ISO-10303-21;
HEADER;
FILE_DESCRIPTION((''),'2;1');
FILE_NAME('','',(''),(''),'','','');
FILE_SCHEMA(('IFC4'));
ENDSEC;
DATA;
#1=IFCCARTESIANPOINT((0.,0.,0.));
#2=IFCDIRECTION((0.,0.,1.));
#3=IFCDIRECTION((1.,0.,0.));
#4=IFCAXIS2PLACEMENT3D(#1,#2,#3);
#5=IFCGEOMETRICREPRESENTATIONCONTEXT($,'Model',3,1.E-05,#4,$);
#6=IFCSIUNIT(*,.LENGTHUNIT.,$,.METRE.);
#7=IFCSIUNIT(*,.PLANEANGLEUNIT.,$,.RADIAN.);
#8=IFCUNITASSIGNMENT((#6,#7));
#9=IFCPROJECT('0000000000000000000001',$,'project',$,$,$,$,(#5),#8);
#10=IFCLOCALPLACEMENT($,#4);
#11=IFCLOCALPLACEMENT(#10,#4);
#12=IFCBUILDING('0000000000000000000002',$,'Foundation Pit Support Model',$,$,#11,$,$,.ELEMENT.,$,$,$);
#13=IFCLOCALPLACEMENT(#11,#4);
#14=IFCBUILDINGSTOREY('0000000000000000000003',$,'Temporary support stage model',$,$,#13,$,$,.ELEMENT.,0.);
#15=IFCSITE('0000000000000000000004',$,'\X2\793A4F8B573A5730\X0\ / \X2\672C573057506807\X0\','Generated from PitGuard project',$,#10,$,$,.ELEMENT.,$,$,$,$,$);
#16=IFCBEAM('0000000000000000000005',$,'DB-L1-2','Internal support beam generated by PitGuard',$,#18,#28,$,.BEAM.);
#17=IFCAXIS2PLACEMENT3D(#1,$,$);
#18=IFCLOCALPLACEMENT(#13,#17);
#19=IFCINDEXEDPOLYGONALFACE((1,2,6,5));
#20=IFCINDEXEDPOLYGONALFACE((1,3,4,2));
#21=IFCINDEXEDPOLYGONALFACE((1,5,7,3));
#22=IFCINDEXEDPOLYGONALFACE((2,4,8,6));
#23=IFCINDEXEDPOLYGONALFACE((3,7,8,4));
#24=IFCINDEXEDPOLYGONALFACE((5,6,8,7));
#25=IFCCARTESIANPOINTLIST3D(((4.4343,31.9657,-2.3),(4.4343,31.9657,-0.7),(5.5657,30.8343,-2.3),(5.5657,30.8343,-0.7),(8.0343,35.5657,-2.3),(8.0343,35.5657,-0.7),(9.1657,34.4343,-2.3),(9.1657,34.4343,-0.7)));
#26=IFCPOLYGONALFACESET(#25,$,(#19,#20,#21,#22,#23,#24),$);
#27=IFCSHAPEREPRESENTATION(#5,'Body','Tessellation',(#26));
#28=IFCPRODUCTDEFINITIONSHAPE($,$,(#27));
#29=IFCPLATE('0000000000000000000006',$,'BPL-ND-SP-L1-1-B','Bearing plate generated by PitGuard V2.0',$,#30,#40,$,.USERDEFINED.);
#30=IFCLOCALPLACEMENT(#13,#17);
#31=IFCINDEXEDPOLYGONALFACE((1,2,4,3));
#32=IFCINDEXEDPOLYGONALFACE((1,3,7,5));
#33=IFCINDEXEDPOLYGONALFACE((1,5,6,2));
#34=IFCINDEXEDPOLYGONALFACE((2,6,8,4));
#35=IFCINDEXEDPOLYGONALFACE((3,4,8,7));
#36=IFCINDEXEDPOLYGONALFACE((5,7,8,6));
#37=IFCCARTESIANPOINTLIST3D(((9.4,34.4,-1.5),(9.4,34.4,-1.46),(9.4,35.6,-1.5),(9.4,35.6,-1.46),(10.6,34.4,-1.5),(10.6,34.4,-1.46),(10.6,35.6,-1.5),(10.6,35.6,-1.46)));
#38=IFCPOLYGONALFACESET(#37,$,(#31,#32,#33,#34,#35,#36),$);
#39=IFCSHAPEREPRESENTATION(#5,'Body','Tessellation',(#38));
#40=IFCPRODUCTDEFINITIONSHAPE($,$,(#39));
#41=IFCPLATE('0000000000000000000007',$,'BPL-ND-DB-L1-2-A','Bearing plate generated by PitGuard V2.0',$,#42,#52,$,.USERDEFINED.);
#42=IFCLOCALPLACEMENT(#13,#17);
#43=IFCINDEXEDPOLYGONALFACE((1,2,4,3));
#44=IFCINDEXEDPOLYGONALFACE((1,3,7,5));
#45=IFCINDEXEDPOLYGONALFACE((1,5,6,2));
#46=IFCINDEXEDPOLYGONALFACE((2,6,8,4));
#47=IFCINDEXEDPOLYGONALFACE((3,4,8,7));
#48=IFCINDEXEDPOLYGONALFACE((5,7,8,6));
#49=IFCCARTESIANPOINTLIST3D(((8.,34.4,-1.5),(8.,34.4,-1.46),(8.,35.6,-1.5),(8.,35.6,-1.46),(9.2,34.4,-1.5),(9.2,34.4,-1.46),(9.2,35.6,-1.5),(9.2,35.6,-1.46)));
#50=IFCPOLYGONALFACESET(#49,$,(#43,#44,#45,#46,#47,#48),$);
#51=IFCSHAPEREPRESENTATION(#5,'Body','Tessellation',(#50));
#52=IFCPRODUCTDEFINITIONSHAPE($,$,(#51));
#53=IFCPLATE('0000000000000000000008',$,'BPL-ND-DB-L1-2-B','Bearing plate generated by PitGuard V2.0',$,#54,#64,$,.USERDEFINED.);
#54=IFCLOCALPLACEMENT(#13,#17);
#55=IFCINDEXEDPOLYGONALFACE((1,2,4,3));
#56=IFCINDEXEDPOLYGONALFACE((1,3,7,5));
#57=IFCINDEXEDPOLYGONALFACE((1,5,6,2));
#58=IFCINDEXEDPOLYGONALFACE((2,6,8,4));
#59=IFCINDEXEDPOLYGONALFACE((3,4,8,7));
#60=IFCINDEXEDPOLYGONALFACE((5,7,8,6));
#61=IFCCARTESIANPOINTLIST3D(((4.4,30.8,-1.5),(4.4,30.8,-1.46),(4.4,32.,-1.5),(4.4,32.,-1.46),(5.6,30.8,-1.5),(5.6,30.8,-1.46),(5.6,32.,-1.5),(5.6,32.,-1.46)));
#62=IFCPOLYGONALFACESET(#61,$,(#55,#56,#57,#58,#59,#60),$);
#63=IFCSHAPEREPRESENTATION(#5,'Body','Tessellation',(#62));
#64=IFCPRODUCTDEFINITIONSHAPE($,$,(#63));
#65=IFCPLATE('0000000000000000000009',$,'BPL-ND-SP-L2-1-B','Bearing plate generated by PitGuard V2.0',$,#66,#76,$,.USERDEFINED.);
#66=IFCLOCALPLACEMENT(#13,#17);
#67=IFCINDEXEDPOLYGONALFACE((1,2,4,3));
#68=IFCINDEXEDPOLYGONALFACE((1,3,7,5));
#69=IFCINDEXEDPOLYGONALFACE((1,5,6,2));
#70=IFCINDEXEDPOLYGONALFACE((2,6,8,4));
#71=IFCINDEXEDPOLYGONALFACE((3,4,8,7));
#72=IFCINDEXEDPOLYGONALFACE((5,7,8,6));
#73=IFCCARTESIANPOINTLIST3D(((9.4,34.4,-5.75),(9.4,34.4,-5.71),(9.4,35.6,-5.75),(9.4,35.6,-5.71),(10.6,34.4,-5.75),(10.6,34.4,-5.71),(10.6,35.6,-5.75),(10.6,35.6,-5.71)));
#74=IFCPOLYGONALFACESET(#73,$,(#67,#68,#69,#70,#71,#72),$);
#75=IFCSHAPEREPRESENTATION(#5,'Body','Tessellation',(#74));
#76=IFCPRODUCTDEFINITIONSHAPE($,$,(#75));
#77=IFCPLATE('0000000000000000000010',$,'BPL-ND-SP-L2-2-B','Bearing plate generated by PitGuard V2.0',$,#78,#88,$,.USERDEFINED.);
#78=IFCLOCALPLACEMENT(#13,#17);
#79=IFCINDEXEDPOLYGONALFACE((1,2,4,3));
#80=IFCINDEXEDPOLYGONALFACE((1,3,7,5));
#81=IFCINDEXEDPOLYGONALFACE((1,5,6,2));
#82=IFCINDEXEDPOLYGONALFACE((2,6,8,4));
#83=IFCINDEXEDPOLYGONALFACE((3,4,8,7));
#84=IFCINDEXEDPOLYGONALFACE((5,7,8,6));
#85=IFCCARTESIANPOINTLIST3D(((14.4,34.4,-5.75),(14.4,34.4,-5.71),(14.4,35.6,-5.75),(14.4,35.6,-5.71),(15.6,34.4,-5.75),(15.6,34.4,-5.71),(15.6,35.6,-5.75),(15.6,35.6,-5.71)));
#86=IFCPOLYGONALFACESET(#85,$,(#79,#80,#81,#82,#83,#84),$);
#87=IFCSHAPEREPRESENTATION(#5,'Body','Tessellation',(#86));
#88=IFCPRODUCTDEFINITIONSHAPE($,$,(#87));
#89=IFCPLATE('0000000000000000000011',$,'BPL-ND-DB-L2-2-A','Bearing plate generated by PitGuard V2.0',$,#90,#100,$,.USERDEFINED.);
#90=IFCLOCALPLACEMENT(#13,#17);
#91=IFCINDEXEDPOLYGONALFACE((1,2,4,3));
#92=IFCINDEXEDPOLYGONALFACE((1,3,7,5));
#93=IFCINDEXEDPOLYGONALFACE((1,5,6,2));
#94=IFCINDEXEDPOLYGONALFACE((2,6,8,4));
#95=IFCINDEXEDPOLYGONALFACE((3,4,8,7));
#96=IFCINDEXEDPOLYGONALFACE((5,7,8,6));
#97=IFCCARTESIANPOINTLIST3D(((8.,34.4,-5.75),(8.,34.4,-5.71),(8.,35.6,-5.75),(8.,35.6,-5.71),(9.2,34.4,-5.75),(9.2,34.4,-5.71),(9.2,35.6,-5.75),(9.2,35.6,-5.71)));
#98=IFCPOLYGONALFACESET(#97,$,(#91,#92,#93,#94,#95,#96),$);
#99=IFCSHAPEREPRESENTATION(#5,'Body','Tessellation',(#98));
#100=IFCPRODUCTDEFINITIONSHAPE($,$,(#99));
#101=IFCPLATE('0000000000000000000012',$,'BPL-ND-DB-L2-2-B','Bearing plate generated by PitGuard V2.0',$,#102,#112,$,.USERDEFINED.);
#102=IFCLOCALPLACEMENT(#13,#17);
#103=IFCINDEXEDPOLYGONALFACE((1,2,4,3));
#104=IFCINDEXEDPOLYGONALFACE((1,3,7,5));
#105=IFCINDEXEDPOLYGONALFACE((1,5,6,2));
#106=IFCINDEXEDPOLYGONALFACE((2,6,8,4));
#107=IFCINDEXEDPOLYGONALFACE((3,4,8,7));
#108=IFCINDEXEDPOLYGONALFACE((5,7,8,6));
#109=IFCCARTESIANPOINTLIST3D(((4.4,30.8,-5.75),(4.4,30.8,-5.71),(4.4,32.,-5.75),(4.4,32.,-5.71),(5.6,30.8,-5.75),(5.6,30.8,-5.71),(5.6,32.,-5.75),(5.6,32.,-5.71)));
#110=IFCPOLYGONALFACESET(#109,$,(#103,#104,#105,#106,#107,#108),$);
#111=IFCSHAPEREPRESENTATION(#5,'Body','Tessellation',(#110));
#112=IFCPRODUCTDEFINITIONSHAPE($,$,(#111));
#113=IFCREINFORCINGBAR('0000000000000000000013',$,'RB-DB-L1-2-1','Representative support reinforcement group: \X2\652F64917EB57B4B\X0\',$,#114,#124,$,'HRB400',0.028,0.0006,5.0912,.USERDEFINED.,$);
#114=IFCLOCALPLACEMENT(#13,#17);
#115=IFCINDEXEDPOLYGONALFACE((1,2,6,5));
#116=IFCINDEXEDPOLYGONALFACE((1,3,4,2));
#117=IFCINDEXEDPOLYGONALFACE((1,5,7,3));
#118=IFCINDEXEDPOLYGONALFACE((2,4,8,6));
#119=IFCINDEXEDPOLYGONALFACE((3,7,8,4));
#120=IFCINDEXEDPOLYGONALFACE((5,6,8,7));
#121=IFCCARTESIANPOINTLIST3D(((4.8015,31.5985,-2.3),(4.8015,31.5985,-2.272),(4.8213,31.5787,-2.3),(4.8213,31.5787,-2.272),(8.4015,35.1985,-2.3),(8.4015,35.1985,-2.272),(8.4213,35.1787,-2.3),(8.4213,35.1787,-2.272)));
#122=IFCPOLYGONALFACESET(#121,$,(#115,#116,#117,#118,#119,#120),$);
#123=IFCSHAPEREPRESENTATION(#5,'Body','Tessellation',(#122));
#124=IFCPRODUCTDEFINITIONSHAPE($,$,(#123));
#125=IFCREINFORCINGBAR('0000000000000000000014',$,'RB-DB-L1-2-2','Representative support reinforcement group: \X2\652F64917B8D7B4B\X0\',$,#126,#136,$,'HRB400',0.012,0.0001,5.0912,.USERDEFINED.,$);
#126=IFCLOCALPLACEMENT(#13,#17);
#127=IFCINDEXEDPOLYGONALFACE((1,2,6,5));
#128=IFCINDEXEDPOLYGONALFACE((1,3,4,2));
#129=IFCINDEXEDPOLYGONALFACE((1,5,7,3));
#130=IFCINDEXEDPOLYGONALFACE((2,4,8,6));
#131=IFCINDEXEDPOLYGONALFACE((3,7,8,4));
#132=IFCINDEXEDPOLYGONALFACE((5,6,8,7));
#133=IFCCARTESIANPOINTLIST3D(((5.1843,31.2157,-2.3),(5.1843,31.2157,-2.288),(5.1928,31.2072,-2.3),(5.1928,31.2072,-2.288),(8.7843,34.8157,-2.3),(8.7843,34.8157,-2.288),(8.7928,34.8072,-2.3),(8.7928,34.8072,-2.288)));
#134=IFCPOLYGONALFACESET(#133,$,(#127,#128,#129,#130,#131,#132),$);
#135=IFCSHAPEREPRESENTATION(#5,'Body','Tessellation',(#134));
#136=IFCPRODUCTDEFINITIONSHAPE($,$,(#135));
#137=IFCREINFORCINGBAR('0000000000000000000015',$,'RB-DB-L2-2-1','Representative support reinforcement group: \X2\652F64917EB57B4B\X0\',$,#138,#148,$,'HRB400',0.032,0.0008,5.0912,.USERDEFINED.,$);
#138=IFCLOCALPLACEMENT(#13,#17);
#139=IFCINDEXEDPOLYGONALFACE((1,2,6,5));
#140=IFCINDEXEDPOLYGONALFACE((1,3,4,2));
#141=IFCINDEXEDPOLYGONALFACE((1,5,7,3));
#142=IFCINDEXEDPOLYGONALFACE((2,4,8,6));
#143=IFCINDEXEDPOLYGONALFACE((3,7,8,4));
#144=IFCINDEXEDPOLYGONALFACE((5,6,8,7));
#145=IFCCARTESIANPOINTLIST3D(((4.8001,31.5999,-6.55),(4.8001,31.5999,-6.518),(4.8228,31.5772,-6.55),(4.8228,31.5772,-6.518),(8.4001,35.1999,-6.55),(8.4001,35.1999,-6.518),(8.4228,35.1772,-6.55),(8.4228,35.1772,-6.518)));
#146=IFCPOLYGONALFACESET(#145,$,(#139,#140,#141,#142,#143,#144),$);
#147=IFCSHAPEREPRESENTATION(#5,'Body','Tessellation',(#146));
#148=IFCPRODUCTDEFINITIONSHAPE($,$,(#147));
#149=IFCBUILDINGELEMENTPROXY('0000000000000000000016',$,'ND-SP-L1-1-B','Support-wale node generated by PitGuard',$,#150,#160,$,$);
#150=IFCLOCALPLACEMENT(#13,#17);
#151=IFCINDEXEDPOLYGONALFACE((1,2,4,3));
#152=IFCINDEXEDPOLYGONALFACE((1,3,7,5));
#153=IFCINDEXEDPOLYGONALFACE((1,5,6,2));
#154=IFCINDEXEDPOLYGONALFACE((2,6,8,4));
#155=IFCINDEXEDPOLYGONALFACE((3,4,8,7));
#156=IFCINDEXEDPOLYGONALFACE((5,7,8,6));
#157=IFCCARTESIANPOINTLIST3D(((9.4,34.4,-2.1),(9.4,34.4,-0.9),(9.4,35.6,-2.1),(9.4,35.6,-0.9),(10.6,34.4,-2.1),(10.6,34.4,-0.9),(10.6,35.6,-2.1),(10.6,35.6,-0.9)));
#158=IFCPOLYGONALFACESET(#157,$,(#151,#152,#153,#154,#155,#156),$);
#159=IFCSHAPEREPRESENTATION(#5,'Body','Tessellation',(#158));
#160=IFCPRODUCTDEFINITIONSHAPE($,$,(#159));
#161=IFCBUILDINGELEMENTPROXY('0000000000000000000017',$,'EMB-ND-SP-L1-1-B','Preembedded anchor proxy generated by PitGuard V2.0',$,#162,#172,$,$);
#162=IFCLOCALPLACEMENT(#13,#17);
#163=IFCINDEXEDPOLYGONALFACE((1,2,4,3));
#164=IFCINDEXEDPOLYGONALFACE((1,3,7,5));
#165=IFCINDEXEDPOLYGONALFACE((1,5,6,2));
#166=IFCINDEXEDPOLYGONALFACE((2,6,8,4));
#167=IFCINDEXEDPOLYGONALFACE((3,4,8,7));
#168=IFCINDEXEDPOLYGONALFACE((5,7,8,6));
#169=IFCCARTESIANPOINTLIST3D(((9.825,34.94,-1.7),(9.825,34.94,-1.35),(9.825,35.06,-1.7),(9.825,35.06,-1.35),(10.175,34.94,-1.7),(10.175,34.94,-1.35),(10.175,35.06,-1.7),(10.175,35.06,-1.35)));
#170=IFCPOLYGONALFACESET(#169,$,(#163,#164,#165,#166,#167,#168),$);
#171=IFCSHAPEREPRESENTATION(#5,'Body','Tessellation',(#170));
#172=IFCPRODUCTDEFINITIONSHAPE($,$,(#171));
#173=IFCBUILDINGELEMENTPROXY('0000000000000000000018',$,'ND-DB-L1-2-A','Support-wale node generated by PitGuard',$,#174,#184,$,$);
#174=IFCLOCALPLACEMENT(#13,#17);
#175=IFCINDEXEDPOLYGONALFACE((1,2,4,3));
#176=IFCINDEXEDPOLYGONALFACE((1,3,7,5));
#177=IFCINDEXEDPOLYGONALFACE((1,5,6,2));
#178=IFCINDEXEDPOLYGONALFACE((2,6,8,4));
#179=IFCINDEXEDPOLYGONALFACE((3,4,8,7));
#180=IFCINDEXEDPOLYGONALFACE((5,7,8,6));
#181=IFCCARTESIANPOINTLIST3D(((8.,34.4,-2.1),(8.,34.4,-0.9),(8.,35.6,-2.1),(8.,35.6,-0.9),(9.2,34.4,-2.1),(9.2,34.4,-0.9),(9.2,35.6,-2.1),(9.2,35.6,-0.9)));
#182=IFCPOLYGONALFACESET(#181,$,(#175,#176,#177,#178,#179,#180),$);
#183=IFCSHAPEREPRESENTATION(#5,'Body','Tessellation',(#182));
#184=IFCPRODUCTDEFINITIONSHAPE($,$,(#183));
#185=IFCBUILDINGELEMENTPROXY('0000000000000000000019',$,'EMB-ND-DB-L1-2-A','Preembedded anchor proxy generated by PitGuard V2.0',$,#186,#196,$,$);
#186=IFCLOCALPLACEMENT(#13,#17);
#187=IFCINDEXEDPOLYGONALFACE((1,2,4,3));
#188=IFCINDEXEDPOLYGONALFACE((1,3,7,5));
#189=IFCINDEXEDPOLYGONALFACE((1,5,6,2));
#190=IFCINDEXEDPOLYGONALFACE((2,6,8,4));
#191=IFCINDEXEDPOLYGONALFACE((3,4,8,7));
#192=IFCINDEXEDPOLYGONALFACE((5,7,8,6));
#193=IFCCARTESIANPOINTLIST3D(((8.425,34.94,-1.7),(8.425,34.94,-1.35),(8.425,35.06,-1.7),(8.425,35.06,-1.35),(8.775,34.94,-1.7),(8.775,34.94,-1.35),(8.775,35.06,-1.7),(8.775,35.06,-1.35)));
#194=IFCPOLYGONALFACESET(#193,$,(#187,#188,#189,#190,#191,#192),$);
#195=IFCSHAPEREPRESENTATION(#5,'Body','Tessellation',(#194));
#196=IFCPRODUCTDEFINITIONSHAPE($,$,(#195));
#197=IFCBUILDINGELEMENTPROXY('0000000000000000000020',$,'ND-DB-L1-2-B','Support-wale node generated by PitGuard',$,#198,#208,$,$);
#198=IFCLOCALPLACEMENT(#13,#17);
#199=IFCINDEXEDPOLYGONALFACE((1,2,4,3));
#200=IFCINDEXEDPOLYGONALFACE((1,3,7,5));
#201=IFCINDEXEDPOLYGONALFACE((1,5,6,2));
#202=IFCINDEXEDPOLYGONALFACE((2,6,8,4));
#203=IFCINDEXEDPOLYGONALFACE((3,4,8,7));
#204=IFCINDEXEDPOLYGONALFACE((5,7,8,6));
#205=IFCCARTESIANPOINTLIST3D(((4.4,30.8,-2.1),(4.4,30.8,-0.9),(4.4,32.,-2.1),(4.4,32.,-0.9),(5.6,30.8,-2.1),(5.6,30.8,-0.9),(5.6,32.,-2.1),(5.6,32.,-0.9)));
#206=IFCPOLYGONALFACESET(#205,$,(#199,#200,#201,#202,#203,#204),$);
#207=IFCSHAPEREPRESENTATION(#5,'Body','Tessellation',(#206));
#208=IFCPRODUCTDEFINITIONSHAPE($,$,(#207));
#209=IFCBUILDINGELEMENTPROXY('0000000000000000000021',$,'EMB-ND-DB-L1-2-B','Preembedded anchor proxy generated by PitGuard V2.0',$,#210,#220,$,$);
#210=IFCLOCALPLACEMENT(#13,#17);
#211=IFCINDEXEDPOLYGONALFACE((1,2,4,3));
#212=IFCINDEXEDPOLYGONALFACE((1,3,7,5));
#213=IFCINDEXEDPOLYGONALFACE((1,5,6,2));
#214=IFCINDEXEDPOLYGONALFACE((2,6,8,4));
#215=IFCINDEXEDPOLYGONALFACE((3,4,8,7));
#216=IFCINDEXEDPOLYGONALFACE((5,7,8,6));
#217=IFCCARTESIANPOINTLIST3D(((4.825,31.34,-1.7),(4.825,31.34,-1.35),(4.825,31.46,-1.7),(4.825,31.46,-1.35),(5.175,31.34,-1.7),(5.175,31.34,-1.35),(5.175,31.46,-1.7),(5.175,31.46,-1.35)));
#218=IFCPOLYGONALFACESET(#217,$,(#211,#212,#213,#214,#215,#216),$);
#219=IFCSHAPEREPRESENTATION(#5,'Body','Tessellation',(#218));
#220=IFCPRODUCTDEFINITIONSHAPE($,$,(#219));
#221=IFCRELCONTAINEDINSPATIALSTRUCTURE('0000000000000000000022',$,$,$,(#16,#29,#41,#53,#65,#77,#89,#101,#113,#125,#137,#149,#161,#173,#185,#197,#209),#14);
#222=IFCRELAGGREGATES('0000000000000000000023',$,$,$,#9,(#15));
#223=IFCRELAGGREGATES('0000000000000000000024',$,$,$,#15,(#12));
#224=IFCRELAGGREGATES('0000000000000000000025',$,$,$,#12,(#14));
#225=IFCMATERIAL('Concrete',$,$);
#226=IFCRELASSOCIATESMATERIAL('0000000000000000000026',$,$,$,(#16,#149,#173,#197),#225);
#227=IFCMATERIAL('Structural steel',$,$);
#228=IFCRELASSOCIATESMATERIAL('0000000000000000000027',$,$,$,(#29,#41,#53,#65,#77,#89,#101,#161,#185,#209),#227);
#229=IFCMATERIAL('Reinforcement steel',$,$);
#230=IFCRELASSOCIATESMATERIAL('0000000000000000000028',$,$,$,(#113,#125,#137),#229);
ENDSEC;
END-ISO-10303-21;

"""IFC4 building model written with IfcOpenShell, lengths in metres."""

from ifc_helpers import new_model, si_unit, frame, origin_with_axes, origin_2d, place, context, project, spatial, rectangle, extrude, material, element, save


model = new_model("IFC4")

# Units and contexts
model_context = context("Model", 3, precision=1e-05, world=origin_with_axes())
ifc_project = project(units=[si_unit("LENGTHUNIT", "METRE"), si_unit("PLANEANGLEUNIT", "RADIAN")], contexts=[model_context])

# Site, building, storey
site_placement = place(None, origin_with_axes())
site = spatial("IfcSite", under=ifc_project, at=site_placement, Name="示例场地 / 本地坐标", Description="Generated from PitGuard project", CompositionType="ELEMENT")
building_placement = place(site_placement, origin_with_axes())
building = spatial("IfcBuilding", under=site, at=building_placement, Name="Foundation Pit Support Model", CompositionType="ELEMENT")
storey_placement = place(building_placement, origin_with_axes())
storey = spatial("IfcBuildingStorey", under=building, at=storey_placement, Name="Temporary support stage model", CompositionType="ELEMENT", Elevation=0.0)

# Beam
ifc_material_1 = material(Name="Concrete")
beam_placement = place(storey_placement, frame((6.8, 33.2, -2.3), z_axis=(0.0, 0.0, 1.0), x_axis=(-0.707107, -0.707107, 0.0)))
element("IfcBeam", 1, at=beam_placement, inside=storey, material=ifc_material_1, Name="DB-L1-2", Description="Internal support beam generated by PitGuard", PredefinedType="BEAM", context=model_context, shape_type="SweptSolid", body=[
    extrude(rectangle(XDim=5.0912, YDim=1.6, at=origin_2d()), origin_with_axes(), (0.0, 0.0, 1.0), 1.6),
])

# Plates
ifc_material_2 = material(Name="Structural steel")
for number, where, z_axis, x_axis, name in (
    (2, (10.0, 35.0, -1.5), (0.0, 0.0, 1.0), (1.0, 0.0, 0.0), "BPL-ND-SP-L1-1-B"),
    (3, (8.6, 35.0, -1.5), (0.0, 0.0, 1.0), (1.0, 0.0, 0.0), "BPL-ND-DB-L1-2-A"),
    (4, (5.0, 31.4, -1.5), (0.0, 0.0, 1.0), (1.0, 0.0, 0.0), "BPL-ND-DB-L1-2-B"),
    (5, (10.0, 35.0, -5.75), (0.0, 0.0, 1.0), (1.0, 0.0, 0.0), "BPL-ND-SP-L2-1-B"),
    (6, (15.0, 35.0, -5.75), (0.0, 0.0, 1.0), (1.0, 0.0, 0.0), "BPL-ND-SP-L2-2-B"),
    (7, (8.6, 35.0, -5.75), (0.0, 0.0, 1.0), (1.0, 0.0, 0.0), "BPL-ND-DB-L2-2-A"),
    (8, (5.0, 31.4, -5.75), (0.0, 0.0, 1.0), (1.0, 0.0, 0.0), "BPL-ND-DB-L2-2-B"),
):
    element("IfcPlate", number, at=place(storey_placement, frame(where, z_axis=z_axis, x_axis=x_axis)), inside=storey, material=ifc_material_2, Name=name, Description="Bearing plate generated by PitGuard V2.0", PredefinedType="USERDEFINED", context=model_context, shape_type="SweptSolid", body=[
        extrude(rectangle(XDim=1.2, YDim=1.2, at=origin_2d()), origin_with_axes(), (0.0, 0.0, 1.0), 0.04),
    ])

# Reinforcing bars
ifc_material_3 = material(Name="Reinforcement steel")
reinforcing_bar_1_placement = place(storey_placement, frame((6.6114, 33.3886, -2.3), z_axis=(0.0, 0.0, 1.0), x_axis=(-0.707107, -0.707107, 0.0)))
element("IfcReinforcingBar", 9, at=reinforcing_bar_1_placement, inside=storey, material=ifc_material_3, Name="RB-DB-L1-2-1", Description="Representative support reinforcement group: 支撑纵筋", SteelGrade="HRB400", BarLength=5.0912, CrossSectionArea=0.0006, NominalDiameter=0.028, PredefinedType="USERDEFINED", context=model_context, shape_type="SweptSolid", body=[
    extrude(rectangle(XDim=5.0912, YDim=0.028, at=origin_2d()), origin_with_axes(), (0.0, 0.0, 1.0), 0.028),
])
reinforcing_bar_2_placement = place(storey_placement, frame((6.9886, 33.0114, -2.3), z_axis=(0.0, 0.0, 1.0), x_axis=(-0.707107, -0.707107, 0.0)))
element("IfcReinforcingBar", 10, at=reinforcing_bar_2_placement, inside=storey, material=ifc_material_3, Name="RB-DB-L1-2-2", Description="Representative support reinforcement group: 支撑箍筋", SteelGrade="HRB400", BarLength=5.0912, CrossSectionArea=0.0001, NominalDiameter=0.012, PredefinedType="USERDEFINED", context=model_context, shape_type="SweptSolid", body=[
    extrude(rectangle(XDim=5.0912, YDim=0.012, at=origin_2d()), origin_with_axes(), (0.0, 0.0, 1.0), 0.012),
])
reinforcing_bar_3_placement = place(storey_placement, frame((6.6114, 33.3886, -6.55), z_axis=(0.0, 0.0, 1.0), x_axis=(-0.707107, -0.707107, 0.0)))
element("IfcReinforcingBar", 11, at=reinforcing_bar_3_placement, inside=storey, material=ifc_material_3, Name="RB-DB-L2-2-1", Description="Representative support reinforcement group: 支撑纵筋", SteelGrade="HRB400", BarLength=5.0912, CrossSectionArea=0.0008, NominalDiameter=0.032, PredefinedType="USERDEFINED", context=model_context, shape_type="SweptSolid", body=[
    extrude(rectangle(XDim=5.0912, YDim=0.032, at=origin_2d()), origin_with_axes(), (0.0, 0.0, 1.0), 0.032),
])

# Building element proxies
proxy_1_placement = place(storey_placement, frame((10.0, 35.0, -2.1), z_axis=(0.0, 0.0, 1.0), x_axis=(1.0, 0.0, 0.0)))
element("IfcBuildingElementProxy", 12, at=proxy_1_placement, inside=storey, material=ifc_material_1, Name="ND-SP-L1-1-B", Description="Support-wale node generated by PitGuard", context=model_context, shape_type="SweptSolid", body=[
    extrude(rectangle(XDim=1.2, YDim=1.2, at=origin_2d()), origin_with_axes(), (0.0, 0.0, 1.0), 1.2),
])
proxy_2_placement = place(storey_placement, frame((10.0, 35.0, -1.7), z_axis=(0.0, 0.0, 1.0), x_axis=(1.0, 0.0, 0.0)))
element("IfcBuildingElementProxy", 13, at=proxy_2_placement, inside=storey, material=ifc_material_2, Name="EMB-ND-SP-L1-1-B", Description="Preembedded anchor proxy generated by PitGuard V2.0", context=model_context, shape_type="SweptSolid", body=[
    extrude(rectangle(XDim=0.35, YDim=0.12, at=origin_2d()), origin_with_axes(), (0.0, 0.0, 1.0), 0.35),
])
proxy_3_placement = place(storey_placement, frame((8.6, 35.0, -2.1), z_axis=(0.0, 0.0, 1.0), x_axis=(1.0, 0.0, 0.0)))
element("IfcBuildingElementProxy", 14, at=proxy_3_placement, inside=storey, material=ifc_material_1, Name="ND-DB-L1-2-A", Description="Support-wale node generated by PitGuard", context=model_context, shape_type="SweptSolid", body=[
    extrude(rectangle(XDim=1.2, YDim=1.2, at=origin_2d()), origin_with_axes(), (0.0, 0.0, 1.0), 1.2),
])
proxy_4_placement = place(storey_placement, frame((8.6, 35.0, -1.7), z_axis=(0.0, 0.0, 1.0), x_axis=(1.0, 0.0, 0.0)))
element("IfcBuildingElementProxy", 15, at=proxy_4_placement, inside=storey, material=ifc_material_2, Name="EMB-ND-DB-L1-2-A", Description="Preembedded anchor proxy generated by PitGuard V2.0", context=model_context, shape_type="SweptSolid", body=[
    extrude(rectangle(XDim=0.35, YDim=0.12, at=origin_2d()), origin_with_axes(), (0.0, 0.0, 1.0), 0.35),
])
proxy_5_placement = place(storey_placement, frame((5.0, 31.4, -2.1), z_axis=(0.0, 0.0, 1.0), x_axis=(1.0, 0.0, 0.0)))
element("IfcBuildingElementProxy", 16, at=proxy_5_placement, inside=storey, material=ifc_material_1, Name="ND-DB-L1-2-B", Description="Support-wale node generated by PitGuard", context=model_context, shape_type="SweptSolid", body=[
    extrude(rectangle(XDim=1.2, YDim=1.2, at=origin_2d()), origin_with_axes(), (0.0, 0.0, 1.0), 1.2),
])
proxy_6_placement = place(storey_placement, frame((5.0, 31.4, -1.7), z_axis=(0.0, 0.0, 1.0), x_axis=(1.0, 0.0, 0.0)))
element("IfcBuildingElementProxy", 17, at=proxy_6_placement, inside=storey, material=ifc_material_2, Name="EMB-ND-DB-L1-2-B", Description="Preembedded anchor proxy generated by PitGuard V2.0", context=model_context, shape_type="SweptSolid", body=[
    extrude(rectangle(XDim=0.35, YDim=0.12, at=origin_2d()), origin_with_axes(), (0.0, 0.0, 1.0), 0.35),
])

save(model, "model.ifc")
